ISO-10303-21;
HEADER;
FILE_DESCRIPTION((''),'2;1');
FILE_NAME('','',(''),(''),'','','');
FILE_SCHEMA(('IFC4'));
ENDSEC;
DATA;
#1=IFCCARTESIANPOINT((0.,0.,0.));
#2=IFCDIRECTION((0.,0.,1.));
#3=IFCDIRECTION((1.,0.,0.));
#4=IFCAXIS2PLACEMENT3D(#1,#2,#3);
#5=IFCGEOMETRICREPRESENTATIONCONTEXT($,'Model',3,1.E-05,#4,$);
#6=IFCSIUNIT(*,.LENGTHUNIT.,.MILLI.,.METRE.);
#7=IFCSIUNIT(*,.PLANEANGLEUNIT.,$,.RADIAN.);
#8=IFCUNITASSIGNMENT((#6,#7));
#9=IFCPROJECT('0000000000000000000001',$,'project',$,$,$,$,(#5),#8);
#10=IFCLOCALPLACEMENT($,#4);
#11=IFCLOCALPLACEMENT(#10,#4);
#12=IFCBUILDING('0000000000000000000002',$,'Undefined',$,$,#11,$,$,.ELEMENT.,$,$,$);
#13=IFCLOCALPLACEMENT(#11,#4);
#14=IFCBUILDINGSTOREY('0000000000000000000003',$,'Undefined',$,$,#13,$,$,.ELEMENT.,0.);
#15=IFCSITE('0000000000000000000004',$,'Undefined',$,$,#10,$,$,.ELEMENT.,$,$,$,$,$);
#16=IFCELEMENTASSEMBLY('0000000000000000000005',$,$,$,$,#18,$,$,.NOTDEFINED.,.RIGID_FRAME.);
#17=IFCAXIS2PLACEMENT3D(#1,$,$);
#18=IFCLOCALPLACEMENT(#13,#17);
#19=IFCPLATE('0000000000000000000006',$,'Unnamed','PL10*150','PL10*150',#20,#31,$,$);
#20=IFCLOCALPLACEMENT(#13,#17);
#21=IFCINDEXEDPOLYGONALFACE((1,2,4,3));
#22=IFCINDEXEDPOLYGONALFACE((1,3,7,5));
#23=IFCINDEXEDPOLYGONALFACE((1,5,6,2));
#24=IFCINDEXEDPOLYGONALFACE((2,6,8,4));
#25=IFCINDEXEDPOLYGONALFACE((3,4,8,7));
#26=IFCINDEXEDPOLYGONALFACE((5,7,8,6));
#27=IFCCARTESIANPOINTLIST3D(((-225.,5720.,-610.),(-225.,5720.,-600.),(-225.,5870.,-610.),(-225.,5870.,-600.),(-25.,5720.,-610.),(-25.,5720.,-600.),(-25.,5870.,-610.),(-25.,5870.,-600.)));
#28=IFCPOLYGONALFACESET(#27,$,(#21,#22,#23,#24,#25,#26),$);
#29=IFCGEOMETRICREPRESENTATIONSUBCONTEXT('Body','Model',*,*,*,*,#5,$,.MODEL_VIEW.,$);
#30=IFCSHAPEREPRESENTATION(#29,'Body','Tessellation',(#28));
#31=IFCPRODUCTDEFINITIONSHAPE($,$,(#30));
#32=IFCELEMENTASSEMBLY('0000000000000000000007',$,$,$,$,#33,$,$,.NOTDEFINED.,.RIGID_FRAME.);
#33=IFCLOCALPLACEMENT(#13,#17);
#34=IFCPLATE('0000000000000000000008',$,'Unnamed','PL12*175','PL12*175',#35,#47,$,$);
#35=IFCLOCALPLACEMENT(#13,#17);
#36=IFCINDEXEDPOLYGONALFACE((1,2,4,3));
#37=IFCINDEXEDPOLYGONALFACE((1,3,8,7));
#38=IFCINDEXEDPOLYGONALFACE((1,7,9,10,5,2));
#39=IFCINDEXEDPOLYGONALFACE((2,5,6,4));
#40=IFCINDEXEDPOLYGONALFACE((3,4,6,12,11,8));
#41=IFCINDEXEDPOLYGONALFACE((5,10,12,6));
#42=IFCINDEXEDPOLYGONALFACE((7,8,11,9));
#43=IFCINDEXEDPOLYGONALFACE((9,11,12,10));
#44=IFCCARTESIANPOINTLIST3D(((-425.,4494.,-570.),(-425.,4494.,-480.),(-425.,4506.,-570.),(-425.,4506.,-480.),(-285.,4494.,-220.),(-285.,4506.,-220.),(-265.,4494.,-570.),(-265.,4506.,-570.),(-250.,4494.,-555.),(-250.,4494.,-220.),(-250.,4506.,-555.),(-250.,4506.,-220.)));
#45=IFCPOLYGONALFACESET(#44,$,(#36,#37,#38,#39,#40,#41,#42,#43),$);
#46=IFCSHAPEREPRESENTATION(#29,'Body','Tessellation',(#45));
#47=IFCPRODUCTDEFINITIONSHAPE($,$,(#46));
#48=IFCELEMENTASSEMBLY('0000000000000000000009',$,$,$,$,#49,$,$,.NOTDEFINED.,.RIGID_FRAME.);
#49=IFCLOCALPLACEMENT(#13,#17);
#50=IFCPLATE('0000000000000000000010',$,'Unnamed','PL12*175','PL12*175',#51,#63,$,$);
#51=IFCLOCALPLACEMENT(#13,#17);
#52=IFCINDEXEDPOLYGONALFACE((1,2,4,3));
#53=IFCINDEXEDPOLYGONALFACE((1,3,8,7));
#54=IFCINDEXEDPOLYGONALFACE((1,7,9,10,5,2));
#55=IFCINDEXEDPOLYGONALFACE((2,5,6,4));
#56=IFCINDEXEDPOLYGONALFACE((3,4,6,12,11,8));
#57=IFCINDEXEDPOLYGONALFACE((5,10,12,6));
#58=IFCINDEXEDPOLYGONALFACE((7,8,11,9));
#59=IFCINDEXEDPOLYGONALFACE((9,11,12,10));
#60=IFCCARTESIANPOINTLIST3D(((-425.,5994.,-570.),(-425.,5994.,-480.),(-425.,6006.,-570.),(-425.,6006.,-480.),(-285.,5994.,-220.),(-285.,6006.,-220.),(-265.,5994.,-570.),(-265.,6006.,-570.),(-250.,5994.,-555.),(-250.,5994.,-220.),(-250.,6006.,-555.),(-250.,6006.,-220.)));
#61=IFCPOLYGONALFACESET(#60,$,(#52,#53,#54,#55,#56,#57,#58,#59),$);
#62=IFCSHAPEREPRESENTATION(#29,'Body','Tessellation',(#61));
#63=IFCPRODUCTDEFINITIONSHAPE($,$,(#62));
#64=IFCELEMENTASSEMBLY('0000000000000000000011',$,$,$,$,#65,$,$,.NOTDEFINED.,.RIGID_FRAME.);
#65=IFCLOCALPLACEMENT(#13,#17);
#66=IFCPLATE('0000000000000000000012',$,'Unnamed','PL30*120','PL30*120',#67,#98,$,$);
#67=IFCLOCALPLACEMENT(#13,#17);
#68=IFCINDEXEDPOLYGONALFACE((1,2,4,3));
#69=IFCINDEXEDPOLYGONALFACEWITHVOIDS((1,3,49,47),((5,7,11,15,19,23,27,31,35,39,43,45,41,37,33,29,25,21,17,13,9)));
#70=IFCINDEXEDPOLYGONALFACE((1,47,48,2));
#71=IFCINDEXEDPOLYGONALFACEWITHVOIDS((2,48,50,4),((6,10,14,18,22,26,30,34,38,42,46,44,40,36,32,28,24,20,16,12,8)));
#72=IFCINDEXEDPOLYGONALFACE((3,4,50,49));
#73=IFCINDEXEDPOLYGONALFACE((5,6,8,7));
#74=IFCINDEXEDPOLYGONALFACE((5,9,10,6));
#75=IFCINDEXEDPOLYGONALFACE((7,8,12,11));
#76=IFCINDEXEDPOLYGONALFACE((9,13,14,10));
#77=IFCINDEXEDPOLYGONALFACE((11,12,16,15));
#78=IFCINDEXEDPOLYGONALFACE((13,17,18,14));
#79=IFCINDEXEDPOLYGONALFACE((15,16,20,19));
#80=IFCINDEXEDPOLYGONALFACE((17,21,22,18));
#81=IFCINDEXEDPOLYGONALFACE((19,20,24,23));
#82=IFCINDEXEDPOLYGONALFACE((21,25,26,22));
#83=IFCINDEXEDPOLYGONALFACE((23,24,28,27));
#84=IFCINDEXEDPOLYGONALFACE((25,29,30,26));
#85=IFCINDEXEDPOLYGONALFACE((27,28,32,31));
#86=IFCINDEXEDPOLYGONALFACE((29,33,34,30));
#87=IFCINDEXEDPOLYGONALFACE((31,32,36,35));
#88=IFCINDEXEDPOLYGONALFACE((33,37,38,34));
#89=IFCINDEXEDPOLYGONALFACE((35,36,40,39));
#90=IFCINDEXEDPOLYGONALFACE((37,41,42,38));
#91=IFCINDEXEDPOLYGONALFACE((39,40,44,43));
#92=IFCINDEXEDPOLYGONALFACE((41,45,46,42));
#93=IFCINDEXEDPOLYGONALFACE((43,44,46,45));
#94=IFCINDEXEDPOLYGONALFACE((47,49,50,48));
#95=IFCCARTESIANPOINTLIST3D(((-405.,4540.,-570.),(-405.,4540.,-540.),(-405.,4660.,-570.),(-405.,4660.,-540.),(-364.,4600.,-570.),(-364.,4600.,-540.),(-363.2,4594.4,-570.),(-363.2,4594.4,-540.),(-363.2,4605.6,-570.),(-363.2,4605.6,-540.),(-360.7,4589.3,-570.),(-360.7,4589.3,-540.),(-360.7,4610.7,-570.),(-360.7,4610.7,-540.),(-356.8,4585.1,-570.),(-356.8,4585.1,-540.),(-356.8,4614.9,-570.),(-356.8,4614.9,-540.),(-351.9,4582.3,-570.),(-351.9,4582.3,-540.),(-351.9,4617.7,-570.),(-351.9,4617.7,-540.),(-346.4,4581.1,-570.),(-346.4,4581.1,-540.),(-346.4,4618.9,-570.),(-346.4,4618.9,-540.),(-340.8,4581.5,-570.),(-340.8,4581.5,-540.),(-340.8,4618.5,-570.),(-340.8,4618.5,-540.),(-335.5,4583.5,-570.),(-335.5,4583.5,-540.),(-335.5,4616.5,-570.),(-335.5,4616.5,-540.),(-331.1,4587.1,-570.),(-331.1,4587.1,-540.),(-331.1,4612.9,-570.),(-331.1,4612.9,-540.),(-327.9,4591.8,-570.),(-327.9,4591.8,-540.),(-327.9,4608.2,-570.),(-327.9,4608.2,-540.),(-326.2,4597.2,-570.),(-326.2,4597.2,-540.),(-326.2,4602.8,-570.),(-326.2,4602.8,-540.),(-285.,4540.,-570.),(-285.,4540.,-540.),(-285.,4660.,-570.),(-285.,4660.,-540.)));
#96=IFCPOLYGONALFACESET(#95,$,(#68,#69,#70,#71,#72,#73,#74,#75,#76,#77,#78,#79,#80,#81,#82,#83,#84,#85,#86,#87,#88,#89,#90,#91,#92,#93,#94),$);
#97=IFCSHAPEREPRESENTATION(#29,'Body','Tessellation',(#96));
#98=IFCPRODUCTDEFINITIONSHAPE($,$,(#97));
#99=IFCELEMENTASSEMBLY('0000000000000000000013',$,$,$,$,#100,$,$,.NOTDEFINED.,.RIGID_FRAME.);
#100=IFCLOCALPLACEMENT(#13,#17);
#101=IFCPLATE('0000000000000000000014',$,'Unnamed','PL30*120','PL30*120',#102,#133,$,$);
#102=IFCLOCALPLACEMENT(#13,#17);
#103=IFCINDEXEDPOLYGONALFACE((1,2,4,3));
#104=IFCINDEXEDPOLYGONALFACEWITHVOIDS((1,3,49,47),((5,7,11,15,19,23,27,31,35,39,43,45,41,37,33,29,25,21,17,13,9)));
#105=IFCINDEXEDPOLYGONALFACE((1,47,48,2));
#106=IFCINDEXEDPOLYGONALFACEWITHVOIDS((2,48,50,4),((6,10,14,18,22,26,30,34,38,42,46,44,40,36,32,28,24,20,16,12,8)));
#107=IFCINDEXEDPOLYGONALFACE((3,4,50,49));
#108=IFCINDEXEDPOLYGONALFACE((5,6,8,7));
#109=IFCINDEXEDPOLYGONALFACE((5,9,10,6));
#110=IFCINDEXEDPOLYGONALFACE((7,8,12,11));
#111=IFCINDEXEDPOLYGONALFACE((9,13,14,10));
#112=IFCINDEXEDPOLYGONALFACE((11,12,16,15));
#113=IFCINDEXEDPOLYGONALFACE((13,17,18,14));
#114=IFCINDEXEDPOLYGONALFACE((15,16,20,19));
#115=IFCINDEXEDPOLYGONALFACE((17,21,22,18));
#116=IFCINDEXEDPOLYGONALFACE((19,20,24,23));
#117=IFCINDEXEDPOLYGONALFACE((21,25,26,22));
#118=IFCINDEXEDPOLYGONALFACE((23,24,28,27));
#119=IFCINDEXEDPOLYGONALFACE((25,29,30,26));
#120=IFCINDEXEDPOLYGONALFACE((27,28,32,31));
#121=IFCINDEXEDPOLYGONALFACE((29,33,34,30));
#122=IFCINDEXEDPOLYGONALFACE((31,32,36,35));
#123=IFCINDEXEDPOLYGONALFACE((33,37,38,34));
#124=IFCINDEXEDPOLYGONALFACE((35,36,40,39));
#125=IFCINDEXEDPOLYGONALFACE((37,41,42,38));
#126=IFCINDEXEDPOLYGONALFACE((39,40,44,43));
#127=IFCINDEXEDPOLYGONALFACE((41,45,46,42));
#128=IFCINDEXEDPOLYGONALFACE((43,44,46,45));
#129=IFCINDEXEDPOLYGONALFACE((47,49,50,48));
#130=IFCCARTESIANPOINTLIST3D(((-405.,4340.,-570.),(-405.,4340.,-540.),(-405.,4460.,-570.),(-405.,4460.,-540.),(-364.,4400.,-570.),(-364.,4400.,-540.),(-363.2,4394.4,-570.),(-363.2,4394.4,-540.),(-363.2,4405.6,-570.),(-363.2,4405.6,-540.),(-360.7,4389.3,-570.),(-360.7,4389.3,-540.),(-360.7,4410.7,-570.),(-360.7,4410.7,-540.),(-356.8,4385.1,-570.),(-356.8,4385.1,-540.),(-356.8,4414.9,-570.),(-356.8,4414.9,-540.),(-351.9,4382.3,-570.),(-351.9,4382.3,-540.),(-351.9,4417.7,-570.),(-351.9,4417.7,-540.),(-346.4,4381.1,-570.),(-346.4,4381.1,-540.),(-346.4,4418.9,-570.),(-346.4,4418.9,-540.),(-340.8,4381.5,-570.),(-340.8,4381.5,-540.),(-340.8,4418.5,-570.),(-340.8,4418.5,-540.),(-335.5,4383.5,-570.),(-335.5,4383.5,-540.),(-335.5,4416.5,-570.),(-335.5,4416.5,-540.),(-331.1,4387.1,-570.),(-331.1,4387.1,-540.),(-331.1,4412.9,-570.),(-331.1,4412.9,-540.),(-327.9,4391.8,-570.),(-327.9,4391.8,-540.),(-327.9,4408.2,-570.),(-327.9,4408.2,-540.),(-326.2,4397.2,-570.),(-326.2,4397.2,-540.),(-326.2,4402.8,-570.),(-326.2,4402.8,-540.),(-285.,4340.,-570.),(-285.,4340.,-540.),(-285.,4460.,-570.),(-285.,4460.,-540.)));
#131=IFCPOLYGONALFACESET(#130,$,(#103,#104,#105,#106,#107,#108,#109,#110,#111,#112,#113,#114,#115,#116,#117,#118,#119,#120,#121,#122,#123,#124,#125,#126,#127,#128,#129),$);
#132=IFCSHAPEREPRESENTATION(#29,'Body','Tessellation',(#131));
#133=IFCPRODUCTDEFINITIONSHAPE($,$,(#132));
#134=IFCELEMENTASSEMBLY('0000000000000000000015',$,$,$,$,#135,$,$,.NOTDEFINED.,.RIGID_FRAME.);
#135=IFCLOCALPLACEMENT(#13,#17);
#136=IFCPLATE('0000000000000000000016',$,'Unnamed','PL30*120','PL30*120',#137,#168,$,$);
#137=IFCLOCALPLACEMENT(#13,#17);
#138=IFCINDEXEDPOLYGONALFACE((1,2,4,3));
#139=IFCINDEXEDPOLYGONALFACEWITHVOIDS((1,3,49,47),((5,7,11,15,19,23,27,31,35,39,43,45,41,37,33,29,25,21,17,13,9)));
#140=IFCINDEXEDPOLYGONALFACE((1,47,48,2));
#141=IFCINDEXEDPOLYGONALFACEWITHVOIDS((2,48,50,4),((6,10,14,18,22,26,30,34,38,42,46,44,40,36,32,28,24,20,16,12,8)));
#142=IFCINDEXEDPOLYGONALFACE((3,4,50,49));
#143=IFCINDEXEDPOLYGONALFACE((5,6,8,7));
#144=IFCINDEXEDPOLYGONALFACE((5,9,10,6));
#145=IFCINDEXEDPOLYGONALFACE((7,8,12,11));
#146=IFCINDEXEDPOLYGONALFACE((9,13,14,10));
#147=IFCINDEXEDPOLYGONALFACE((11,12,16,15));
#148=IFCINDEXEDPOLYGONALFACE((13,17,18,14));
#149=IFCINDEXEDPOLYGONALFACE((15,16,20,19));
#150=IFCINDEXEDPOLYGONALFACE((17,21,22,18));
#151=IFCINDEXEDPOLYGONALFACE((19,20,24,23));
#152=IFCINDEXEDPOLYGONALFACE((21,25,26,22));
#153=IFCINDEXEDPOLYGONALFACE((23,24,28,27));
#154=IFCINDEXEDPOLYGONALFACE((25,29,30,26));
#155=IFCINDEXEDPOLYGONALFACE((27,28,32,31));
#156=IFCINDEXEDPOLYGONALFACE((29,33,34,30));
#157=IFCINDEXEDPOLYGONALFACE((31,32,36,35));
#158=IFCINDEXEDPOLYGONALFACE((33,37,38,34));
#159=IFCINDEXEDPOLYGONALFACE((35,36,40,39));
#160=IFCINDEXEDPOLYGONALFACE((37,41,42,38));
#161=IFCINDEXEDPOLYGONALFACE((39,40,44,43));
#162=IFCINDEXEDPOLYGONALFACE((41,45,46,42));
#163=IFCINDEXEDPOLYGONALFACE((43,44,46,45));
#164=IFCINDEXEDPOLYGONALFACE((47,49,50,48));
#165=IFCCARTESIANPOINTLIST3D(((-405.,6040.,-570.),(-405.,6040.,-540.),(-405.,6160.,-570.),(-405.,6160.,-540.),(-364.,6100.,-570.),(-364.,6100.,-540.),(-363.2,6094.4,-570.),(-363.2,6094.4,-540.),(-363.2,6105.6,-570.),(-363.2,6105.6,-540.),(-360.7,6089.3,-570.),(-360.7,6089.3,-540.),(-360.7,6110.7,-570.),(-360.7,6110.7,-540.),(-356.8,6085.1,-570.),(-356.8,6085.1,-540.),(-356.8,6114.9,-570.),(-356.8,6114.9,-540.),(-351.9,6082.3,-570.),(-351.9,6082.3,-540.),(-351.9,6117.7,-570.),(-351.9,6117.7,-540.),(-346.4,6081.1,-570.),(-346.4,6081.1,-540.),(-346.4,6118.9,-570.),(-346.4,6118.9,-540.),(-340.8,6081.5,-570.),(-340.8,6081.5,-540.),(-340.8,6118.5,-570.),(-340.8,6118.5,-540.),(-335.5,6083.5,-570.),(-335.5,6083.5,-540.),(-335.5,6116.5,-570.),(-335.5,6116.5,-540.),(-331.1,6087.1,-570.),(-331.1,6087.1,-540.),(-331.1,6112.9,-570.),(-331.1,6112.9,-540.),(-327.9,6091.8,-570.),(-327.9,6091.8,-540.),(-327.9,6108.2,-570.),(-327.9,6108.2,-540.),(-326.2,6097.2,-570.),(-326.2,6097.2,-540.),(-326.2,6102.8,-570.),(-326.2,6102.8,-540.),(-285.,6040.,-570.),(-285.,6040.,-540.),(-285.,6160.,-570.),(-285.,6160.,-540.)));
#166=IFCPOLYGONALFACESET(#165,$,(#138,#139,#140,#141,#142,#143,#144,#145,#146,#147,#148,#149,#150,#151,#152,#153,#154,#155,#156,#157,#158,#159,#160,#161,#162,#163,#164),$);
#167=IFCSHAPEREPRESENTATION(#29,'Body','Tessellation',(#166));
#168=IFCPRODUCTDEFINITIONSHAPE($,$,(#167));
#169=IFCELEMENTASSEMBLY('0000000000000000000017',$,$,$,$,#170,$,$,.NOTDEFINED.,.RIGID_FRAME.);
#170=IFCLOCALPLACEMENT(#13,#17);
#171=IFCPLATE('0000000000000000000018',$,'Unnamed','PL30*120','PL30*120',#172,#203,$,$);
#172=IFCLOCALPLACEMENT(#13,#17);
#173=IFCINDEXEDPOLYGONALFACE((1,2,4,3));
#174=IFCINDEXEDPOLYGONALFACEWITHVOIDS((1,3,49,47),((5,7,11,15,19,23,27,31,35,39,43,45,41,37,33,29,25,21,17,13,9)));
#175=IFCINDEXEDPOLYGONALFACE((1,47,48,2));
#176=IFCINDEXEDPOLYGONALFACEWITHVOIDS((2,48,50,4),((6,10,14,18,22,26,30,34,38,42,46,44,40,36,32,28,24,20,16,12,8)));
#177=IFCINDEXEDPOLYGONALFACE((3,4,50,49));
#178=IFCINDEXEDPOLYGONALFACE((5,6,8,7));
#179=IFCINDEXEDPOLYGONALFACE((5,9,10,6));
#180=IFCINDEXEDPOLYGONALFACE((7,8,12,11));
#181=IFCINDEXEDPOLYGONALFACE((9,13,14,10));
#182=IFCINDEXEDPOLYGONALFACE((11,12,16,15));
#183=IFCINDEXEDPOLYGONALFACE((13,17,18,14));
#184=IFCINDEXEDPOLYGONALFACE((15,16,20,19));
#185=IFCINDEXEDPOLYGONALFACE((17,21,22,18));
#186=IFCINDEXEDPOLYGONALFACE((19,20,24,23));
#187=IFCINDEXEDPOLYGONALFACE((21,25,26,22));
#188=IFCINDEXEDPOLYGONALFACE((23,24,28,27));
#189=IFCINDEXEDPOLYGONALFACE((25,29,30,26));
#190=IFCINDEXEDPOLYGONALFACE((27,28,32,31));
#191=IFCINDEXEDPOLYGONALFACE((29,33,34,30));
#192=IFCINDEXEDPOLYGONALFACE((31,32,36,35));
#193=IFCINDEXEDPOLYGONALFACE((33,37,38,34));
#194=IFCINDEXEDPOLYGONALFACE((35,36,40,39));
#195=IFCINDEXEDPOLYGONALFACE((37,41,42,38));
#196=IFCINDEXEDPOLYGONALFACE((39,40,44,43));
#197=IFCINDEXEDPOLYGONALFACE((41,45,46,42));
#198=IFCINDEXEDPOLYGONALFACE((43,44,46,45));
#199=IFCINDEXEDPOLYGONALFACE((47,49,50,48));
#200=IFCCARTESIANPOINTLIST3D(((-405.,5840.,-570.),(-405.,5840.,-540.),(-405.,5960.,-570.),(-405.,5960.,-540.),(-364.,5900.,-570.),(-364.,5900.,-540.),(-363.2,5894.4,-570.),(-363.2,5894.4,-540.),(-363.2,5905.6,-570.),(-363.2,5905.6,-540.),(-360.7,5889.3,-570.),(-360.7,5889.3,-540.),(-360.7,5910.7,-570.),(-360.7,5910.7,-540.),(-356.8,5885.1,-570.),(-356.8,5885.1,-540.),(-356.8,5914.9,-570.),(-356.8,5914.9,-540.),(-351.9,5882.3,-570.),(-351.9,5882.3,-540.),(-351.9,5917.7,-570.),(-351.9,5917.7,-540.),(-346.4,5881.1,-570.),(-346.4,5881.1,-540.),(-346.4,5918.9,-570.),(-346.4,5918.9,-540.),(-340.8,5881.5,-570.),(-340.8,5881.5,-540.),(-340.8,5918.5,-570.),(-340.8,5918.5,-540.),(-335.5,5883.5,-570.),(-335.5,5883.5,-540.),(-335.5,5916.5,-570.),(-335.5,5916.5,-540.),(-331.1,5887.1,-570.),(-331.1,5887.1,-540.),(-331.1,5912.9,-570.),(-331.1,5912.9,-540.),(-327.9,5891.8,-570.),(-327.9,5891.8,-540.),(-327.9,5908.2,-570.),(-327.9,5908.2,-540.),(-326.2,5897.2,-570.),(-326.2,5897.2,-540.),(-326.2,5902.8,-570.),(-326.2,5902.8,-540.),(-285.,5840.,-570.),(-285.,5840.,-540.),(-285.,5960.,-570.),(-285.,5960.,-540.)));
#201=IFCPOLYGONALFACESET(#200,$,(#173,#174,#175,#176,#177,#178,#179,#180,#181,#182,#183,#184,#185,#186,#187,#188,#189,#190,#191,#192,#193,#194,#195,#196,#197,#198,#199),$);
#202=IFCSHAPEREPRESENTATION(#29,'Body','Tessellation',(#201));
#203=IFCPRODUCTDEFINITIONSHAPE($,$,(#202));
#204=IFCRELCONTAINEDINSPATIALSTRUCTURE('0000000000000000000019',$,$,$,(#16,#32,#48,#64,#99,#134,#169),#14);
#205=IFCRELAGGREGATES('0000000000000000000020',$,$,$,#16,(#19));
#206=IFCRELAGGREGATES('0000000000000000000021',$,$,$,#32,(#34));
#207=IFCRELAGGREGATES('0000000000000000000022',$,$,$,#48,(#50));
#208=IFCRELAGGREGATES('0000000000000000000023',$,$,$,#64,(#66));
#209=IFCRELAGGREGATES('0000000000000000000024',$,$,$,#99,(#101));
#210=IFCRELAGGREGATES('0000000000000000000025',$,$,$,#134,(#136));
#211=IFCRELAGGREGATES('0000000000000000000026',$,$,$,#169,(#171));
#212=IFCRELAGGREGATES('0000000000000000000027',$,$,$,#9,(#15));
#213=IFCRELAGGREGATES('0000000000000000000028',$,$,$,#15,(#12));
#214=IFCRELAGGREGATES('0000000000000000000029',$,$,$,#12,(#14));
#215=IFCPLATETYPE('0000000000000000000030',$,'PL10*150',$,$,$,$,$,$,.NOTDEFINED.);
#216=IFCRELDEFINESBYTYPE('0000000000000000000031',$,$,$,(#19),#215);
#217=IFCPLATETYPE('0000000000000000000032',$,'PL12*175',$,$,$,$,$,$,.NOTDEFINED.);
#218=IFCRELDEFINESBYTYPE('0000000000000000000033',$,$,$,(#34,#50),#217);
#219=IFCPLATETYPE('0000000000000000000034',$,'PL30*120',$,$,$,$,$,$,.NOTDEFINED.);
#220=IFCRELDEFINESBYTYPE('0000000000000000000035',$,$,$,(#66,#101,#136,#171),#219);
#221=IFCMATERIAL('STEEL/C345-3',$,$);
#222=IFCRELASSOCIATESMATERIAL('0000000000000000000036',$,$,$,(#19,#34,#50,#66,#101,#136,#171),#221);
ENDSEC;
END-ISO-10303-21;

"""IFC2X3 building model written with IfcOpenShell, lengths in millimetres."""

from ifc_helpers import new_model, si_unit, frame, origin_with_axes, origin_2d_with_axis, place, context, subcontext, project, spatial, polyline, circle, outline, extrude, boolean, material, type_object, element, aggregate, save


model = new_model("IFC2X3")

# Units and contexts
model_context = context("Model", 3, precision=1e-05, world=origin_with_axes())
body_context = subcontext(model_context, "Body", "Model", "MODEL_VIEW")
ifc_project = project(units=[si_unit("LENGTHUNIT", "METRE", prefix="MILLI"), si_unit("PLANEANGLEUNIT", "RADIAN")], contexts=[model_context])

# Site, building, storey
site_placement = place(None, origin_with_axes())
site = spatial("IfcSite", under=ifc_project, at=site_placement, Name="Undefined", CompositionType="ELEMENT")
building_placement = place(site_placement, origin_with_axes())
building = spatial("IfcBuilding", under=site, at=building_placement, Name="Undefined", CompositionType="ELEMENT")
storey_placement = place(building_placement, origin_with_axes())
storey = spatial("IfcBuildingStorey", under=building, at=storey_placement, Name="Undefined", CompositionType="ELEMENT", Elevation=0.0)

# Shared definitions
ifc_material_1 = material(Name="STEEL/C345-3")

# Element assemblies, plates
plate_type_1 = type_object("IfcPlateType", Name="PL10*150", PredefinedType="NOTDEFINED")
assembly_1_placement = place(storey_placement, origin_with_axes())
assembly_1 = element("IfcElementAssembly", 1, at=assembly_1_placement, inside=storey, AssemblyPlace="NOTDEFINED", PredefinedType="RIGID_FRAME")
plate_1_placement = place(assembly_1_placement, frame((-25.0, 5870.0, -605.0), z_axis=(0.0, 0.0, -1.0), x_axis=(0.0, -1.0, 0.0)))
plate_1 = element("IfcPlate", 2, at=plate_1_placement, type_object=plate_type_1, material=ifc_material_1, Name="Unnamed", Description="PL10*150", ObjectType="PL10*150", context=body_context, shape_type="SweptSolid", body=[
    extrude(outline(polyline([(0.0, 0.0), (150.0, 0.0), (150.0, 200.0), (0.0, 200.0), (0.0, 0.0)])), frame((0.0, 0.0, -5.0), z_axis=(0.0, 0.0, 1.0), x_axis=(1.0, 0.0, 0.0)), (0.0, 0.0, 1.0), 10.0),
])
aggregate(assembly_1, [plate_1])
assembly_2_placement = place(storey_placement, origin_with_axes())
assembly_2 = element("IfcElementAssembly", 3, at=assembly_2_placement, inside=storey, AssemblyPlace="NOTDEFINED", PredefinedType="RIGID_FRAME")
plate_type_2 = type_object("IfcPlateType", Name="PL12*175", PredefinedType="NOTDEFINED")
plate_2_placement = place(assembly_2_placement, frame((-425.0, 4500.0, -570.0), z_axis=(0.0, -1.0, 0.0), x_axis=(1.0, 0.0, 0.0)))
plate_2 = element("IfcPlate", 4, at=plate_2_placement, type_object=plate_type_2, material=ifc_material_1, Name="Unnamed", Description="PL12*175", ObjectType="PL12*175", context=body_context, shape_type="SweptSolid", body=[
    extrude(outline(polyline([(0.0, 0.0), (160.0, 0.0), (175.0, 15.0), (175.0, 350.0), (140.0, 350.0), (0.0, 90.0), (0.0, 0.0)])), frame((0.0, 0.0, -6.0), z_axis=(0.0, 0.0, 1.0), x_axis=(1.0, 0.0, 0.0)), (0.0, 0.0, 1.0), 12.0),
])
aggregate(assembly_2, [plate_2])
assembly_3_placement = place(storey_placement, origin_with_axes())
assembly_3 = element("IfcElementAssembly", 5, at=assembly_3_placement, inside=storey, AssemblyPlace="NOTDEFINED", PredefinedType="RIGID_FRAME")
plate_3_placement = place(assembly_3_placement, frame((-425.0, 6000.0, -570.0), z_axis=(0.0, -1.0, 0.0), x_axis=(1.0, 0.0, 0.0)))
plate_3 = element("IfcPlate", 6, at=plate_3_placement, type_object=plate_type_2, material=ifc_material_1, Name="Unnamed", Description="PL12*175", ObjectType="PL12*175", context=body_context, shape_type="SweptSolid", body=[
    extrude(outline(polyline([(0.0, 0.0), (160.0, 0.0), (175.0, 15.0), (175.0, 350.0), (140.0, 350.0), (0.0, 90.0), (0.0, 0.0)])), frame((0.0, 0.0, -6.0), z_axis=(0.0, 0.0, 1.0), x_axis=(1.0, 0.0, 0.0)), (0.0, 0.0, 1.0), 12.0),
])
aggregate(assembly_3, [plate_3])
assembly_4_placement = place(storey_placement, origin_with_axes())
assembly_4 = element("IfcElementAssembly", 7, at=assembly_4_placement, inside=storey, AssemblyPlace="NOTDEFINED", PredefinedType="RIGID_FRAME")
plate_type_3 = type_object("IfcPlateType", Name="PL30*120", PredefinedType="NOTDEFINED")
plate_4_placement = place(assembly_4_placement, frame((-285.0, 4540.0, -555.0), z_axis=(0.0, 0.0, 1.0), x_axis=(0.0, 1.0, 0.0)))
plate_4 = element("IfcPlate", 8, at=plate_4_placement, type_object=plate_type_3, material=ifc_material_1, Name="Unnamed", Description="PL30*120", ObjectType="PL30*120", context=body_context, shape_type="CSG", body=[
    boolean("DIFFERENCE", extrude(outline(polyline([(0.0, 0.0), (120.0, 0.0), (120.0, 120.0), (0.0, 120.0), (0.0, 0.0)])), frame((0.0, 0.0, -15.0), z_axis=(0.0, 0.0, 1.0), x_axis=(1.0, 0.0, 0.0)), (0.0, 0.0, 1.0), 30.0), extrude(circle(Radius=19.0, at=origin_2d_with_axis()), frame((60.0, 60.0, 45.0), z_axis=(0.0, 0.0, -1.0), x_axis=(0.0, 1.0, 0.0)), (0.0, 0.0, 1.0), 80.0)),
])
aggregate(assembly_4, [plate_4])
assembly_5_placement = place(storey_placement, origin_with_axes())
assembly_5 = element("IfcElementAssembly", 9, at=assembly_5_placement, inside=storey, AssemblyPlace="NOTDEFINED", PredefinedType="RIGID_FRAME")
plate_5_placement = place(assembly_5_placement, frame((-285.0, 4340.0, -555.0), z_axis=(0.0, 0.0, 1.0), x_axis=(0.0, 1.0, 0.0)))
plate_5 = element("IfcPlate", 10, at=plate_5_placement, type_object=plate_type_3, material=ifc_material_1, Name="Unnamed", Description="PL30*120", ObjectType="PL30*120", context=body_context, shape_type="CSG", body=[
    boolean("DIFFERENCE", extrude(outline(polyline([(0.0, 0.0), (120.0, 0.0), (120.0, 120.0), (0.0, 120.0), (0.0, 0.0)])), frame((0.0, 0.0, -15.0), z_axis=(0.0, 0.0, 1.0), x_axis=(1.0, 0.0, 0.0)), (0.0, 0.0, 1.0), 30.0), extrude(circle(Radius=19.0, at=origin_2d_with_axis()), frame((60.0, 60.0, 45.0), z_axis=(0.0, 0.0, -1.0), x_axis=(0.0, 1.0, 0.0)), (0.0, 0.0, 1.0), 80.0)),
])
aggregate(assembly_5, [plate_5])
assembly_6_placement = place(storey_placement, origin_with_axes())
assembly_6 = element("IfcElementAssembly", 11, at=assembly_6_placement, inside=storey, AssemblyPlace="NOTDEFINED", PredefinedType="RIGID_FRAME")
plate_6_placement = place(assembly_6_placement, frame((-285.0, 6040.0, -555.0), z_axis=(0.0, 0.0, 1.0), x_axis=(0.0, 1.0, 0.0)))
plate_6 = element("IfcPlate", 12, at=plate_6_placement, type_object=plate_type_3, material=ifc_material_1, Name="Unnamed", Description="PL30*120", ObjectType="PL30*120", context=body_context, shape_type="CSG", body=[
    boolean("DIFFERENCE", extrude(outline(polyline([(0.0, 0.0), (120.0, 0.0), (120.0, 120.0), (0.0, 120.0), (0.0, 0.0)])), frame((0.0, 0.0, -15.0), z_axis=(0.0, 0.0, 1.0), x_axis=(1.0, 0.0, 0.0)), (0.0, 0.0, 1.0), 30.0), extrude(circle(Radius=19.0, at=origin_2d_with_axis()), frame((60.0, 60.0, 45.0), z_axis=(0.0, 0.0, -1.0), x_axis=(0.0, 1.0, 0.0)), (0.0, 0.0, 1.0), 80.0)),
])
aggregate(assembly_6, [plate_6])
assembly_7_placement = place(storey_placement, origin_with_axes())
assembly_7 = element("IfcElementAssembly", 13, at=assembly_7_placement, inside=storey, AssemblyPlace="NOTDEFINED", PredefinedType="RIGID_FRAME")
plate_7_placement = place(assembly_7_placement, frame((-285.0, 5840.0, -555.0), z_axis=(0.0, 0.0, 1.0), x_axis=(0.0, 1.0, 0.0)))
plate_7 = element("IfcPlate", 14, at=plate_7_placement, type_object=plate_type_3, material=ifc_material_1, Name="Unnamed", Description="PL30*120", ObjectType="PL30*120", context=body_context, shape_type="CSG", body=[
    boolean("DIFFERENCE", extrude(outline(polyline([(0.0, 0.0), (120.0, 0.0), (120.0, 120.0), (0.0, 120.0), (0.0, 0.0)])), frame((0.0, 0.0, -15.0), z_axis=(0.0, 0.0, 1.0), x_axis=(1.0, 0.0, 0.0)), (0.0, 0.0, 1.0), 30.0), extrude(circle(Radius=19.0, at=origin_2d_with_axis()), frame((60.0, 60.0, 45.0), z_axis=(0.0, 0.0, -1.0), x_axis=(0.0, 1.0, 0.0)), (0.0, 0.0, 1.0), 80.0)),
])
aggregate(assembly_7, [plate_7])

save(model, "model.ifc")
